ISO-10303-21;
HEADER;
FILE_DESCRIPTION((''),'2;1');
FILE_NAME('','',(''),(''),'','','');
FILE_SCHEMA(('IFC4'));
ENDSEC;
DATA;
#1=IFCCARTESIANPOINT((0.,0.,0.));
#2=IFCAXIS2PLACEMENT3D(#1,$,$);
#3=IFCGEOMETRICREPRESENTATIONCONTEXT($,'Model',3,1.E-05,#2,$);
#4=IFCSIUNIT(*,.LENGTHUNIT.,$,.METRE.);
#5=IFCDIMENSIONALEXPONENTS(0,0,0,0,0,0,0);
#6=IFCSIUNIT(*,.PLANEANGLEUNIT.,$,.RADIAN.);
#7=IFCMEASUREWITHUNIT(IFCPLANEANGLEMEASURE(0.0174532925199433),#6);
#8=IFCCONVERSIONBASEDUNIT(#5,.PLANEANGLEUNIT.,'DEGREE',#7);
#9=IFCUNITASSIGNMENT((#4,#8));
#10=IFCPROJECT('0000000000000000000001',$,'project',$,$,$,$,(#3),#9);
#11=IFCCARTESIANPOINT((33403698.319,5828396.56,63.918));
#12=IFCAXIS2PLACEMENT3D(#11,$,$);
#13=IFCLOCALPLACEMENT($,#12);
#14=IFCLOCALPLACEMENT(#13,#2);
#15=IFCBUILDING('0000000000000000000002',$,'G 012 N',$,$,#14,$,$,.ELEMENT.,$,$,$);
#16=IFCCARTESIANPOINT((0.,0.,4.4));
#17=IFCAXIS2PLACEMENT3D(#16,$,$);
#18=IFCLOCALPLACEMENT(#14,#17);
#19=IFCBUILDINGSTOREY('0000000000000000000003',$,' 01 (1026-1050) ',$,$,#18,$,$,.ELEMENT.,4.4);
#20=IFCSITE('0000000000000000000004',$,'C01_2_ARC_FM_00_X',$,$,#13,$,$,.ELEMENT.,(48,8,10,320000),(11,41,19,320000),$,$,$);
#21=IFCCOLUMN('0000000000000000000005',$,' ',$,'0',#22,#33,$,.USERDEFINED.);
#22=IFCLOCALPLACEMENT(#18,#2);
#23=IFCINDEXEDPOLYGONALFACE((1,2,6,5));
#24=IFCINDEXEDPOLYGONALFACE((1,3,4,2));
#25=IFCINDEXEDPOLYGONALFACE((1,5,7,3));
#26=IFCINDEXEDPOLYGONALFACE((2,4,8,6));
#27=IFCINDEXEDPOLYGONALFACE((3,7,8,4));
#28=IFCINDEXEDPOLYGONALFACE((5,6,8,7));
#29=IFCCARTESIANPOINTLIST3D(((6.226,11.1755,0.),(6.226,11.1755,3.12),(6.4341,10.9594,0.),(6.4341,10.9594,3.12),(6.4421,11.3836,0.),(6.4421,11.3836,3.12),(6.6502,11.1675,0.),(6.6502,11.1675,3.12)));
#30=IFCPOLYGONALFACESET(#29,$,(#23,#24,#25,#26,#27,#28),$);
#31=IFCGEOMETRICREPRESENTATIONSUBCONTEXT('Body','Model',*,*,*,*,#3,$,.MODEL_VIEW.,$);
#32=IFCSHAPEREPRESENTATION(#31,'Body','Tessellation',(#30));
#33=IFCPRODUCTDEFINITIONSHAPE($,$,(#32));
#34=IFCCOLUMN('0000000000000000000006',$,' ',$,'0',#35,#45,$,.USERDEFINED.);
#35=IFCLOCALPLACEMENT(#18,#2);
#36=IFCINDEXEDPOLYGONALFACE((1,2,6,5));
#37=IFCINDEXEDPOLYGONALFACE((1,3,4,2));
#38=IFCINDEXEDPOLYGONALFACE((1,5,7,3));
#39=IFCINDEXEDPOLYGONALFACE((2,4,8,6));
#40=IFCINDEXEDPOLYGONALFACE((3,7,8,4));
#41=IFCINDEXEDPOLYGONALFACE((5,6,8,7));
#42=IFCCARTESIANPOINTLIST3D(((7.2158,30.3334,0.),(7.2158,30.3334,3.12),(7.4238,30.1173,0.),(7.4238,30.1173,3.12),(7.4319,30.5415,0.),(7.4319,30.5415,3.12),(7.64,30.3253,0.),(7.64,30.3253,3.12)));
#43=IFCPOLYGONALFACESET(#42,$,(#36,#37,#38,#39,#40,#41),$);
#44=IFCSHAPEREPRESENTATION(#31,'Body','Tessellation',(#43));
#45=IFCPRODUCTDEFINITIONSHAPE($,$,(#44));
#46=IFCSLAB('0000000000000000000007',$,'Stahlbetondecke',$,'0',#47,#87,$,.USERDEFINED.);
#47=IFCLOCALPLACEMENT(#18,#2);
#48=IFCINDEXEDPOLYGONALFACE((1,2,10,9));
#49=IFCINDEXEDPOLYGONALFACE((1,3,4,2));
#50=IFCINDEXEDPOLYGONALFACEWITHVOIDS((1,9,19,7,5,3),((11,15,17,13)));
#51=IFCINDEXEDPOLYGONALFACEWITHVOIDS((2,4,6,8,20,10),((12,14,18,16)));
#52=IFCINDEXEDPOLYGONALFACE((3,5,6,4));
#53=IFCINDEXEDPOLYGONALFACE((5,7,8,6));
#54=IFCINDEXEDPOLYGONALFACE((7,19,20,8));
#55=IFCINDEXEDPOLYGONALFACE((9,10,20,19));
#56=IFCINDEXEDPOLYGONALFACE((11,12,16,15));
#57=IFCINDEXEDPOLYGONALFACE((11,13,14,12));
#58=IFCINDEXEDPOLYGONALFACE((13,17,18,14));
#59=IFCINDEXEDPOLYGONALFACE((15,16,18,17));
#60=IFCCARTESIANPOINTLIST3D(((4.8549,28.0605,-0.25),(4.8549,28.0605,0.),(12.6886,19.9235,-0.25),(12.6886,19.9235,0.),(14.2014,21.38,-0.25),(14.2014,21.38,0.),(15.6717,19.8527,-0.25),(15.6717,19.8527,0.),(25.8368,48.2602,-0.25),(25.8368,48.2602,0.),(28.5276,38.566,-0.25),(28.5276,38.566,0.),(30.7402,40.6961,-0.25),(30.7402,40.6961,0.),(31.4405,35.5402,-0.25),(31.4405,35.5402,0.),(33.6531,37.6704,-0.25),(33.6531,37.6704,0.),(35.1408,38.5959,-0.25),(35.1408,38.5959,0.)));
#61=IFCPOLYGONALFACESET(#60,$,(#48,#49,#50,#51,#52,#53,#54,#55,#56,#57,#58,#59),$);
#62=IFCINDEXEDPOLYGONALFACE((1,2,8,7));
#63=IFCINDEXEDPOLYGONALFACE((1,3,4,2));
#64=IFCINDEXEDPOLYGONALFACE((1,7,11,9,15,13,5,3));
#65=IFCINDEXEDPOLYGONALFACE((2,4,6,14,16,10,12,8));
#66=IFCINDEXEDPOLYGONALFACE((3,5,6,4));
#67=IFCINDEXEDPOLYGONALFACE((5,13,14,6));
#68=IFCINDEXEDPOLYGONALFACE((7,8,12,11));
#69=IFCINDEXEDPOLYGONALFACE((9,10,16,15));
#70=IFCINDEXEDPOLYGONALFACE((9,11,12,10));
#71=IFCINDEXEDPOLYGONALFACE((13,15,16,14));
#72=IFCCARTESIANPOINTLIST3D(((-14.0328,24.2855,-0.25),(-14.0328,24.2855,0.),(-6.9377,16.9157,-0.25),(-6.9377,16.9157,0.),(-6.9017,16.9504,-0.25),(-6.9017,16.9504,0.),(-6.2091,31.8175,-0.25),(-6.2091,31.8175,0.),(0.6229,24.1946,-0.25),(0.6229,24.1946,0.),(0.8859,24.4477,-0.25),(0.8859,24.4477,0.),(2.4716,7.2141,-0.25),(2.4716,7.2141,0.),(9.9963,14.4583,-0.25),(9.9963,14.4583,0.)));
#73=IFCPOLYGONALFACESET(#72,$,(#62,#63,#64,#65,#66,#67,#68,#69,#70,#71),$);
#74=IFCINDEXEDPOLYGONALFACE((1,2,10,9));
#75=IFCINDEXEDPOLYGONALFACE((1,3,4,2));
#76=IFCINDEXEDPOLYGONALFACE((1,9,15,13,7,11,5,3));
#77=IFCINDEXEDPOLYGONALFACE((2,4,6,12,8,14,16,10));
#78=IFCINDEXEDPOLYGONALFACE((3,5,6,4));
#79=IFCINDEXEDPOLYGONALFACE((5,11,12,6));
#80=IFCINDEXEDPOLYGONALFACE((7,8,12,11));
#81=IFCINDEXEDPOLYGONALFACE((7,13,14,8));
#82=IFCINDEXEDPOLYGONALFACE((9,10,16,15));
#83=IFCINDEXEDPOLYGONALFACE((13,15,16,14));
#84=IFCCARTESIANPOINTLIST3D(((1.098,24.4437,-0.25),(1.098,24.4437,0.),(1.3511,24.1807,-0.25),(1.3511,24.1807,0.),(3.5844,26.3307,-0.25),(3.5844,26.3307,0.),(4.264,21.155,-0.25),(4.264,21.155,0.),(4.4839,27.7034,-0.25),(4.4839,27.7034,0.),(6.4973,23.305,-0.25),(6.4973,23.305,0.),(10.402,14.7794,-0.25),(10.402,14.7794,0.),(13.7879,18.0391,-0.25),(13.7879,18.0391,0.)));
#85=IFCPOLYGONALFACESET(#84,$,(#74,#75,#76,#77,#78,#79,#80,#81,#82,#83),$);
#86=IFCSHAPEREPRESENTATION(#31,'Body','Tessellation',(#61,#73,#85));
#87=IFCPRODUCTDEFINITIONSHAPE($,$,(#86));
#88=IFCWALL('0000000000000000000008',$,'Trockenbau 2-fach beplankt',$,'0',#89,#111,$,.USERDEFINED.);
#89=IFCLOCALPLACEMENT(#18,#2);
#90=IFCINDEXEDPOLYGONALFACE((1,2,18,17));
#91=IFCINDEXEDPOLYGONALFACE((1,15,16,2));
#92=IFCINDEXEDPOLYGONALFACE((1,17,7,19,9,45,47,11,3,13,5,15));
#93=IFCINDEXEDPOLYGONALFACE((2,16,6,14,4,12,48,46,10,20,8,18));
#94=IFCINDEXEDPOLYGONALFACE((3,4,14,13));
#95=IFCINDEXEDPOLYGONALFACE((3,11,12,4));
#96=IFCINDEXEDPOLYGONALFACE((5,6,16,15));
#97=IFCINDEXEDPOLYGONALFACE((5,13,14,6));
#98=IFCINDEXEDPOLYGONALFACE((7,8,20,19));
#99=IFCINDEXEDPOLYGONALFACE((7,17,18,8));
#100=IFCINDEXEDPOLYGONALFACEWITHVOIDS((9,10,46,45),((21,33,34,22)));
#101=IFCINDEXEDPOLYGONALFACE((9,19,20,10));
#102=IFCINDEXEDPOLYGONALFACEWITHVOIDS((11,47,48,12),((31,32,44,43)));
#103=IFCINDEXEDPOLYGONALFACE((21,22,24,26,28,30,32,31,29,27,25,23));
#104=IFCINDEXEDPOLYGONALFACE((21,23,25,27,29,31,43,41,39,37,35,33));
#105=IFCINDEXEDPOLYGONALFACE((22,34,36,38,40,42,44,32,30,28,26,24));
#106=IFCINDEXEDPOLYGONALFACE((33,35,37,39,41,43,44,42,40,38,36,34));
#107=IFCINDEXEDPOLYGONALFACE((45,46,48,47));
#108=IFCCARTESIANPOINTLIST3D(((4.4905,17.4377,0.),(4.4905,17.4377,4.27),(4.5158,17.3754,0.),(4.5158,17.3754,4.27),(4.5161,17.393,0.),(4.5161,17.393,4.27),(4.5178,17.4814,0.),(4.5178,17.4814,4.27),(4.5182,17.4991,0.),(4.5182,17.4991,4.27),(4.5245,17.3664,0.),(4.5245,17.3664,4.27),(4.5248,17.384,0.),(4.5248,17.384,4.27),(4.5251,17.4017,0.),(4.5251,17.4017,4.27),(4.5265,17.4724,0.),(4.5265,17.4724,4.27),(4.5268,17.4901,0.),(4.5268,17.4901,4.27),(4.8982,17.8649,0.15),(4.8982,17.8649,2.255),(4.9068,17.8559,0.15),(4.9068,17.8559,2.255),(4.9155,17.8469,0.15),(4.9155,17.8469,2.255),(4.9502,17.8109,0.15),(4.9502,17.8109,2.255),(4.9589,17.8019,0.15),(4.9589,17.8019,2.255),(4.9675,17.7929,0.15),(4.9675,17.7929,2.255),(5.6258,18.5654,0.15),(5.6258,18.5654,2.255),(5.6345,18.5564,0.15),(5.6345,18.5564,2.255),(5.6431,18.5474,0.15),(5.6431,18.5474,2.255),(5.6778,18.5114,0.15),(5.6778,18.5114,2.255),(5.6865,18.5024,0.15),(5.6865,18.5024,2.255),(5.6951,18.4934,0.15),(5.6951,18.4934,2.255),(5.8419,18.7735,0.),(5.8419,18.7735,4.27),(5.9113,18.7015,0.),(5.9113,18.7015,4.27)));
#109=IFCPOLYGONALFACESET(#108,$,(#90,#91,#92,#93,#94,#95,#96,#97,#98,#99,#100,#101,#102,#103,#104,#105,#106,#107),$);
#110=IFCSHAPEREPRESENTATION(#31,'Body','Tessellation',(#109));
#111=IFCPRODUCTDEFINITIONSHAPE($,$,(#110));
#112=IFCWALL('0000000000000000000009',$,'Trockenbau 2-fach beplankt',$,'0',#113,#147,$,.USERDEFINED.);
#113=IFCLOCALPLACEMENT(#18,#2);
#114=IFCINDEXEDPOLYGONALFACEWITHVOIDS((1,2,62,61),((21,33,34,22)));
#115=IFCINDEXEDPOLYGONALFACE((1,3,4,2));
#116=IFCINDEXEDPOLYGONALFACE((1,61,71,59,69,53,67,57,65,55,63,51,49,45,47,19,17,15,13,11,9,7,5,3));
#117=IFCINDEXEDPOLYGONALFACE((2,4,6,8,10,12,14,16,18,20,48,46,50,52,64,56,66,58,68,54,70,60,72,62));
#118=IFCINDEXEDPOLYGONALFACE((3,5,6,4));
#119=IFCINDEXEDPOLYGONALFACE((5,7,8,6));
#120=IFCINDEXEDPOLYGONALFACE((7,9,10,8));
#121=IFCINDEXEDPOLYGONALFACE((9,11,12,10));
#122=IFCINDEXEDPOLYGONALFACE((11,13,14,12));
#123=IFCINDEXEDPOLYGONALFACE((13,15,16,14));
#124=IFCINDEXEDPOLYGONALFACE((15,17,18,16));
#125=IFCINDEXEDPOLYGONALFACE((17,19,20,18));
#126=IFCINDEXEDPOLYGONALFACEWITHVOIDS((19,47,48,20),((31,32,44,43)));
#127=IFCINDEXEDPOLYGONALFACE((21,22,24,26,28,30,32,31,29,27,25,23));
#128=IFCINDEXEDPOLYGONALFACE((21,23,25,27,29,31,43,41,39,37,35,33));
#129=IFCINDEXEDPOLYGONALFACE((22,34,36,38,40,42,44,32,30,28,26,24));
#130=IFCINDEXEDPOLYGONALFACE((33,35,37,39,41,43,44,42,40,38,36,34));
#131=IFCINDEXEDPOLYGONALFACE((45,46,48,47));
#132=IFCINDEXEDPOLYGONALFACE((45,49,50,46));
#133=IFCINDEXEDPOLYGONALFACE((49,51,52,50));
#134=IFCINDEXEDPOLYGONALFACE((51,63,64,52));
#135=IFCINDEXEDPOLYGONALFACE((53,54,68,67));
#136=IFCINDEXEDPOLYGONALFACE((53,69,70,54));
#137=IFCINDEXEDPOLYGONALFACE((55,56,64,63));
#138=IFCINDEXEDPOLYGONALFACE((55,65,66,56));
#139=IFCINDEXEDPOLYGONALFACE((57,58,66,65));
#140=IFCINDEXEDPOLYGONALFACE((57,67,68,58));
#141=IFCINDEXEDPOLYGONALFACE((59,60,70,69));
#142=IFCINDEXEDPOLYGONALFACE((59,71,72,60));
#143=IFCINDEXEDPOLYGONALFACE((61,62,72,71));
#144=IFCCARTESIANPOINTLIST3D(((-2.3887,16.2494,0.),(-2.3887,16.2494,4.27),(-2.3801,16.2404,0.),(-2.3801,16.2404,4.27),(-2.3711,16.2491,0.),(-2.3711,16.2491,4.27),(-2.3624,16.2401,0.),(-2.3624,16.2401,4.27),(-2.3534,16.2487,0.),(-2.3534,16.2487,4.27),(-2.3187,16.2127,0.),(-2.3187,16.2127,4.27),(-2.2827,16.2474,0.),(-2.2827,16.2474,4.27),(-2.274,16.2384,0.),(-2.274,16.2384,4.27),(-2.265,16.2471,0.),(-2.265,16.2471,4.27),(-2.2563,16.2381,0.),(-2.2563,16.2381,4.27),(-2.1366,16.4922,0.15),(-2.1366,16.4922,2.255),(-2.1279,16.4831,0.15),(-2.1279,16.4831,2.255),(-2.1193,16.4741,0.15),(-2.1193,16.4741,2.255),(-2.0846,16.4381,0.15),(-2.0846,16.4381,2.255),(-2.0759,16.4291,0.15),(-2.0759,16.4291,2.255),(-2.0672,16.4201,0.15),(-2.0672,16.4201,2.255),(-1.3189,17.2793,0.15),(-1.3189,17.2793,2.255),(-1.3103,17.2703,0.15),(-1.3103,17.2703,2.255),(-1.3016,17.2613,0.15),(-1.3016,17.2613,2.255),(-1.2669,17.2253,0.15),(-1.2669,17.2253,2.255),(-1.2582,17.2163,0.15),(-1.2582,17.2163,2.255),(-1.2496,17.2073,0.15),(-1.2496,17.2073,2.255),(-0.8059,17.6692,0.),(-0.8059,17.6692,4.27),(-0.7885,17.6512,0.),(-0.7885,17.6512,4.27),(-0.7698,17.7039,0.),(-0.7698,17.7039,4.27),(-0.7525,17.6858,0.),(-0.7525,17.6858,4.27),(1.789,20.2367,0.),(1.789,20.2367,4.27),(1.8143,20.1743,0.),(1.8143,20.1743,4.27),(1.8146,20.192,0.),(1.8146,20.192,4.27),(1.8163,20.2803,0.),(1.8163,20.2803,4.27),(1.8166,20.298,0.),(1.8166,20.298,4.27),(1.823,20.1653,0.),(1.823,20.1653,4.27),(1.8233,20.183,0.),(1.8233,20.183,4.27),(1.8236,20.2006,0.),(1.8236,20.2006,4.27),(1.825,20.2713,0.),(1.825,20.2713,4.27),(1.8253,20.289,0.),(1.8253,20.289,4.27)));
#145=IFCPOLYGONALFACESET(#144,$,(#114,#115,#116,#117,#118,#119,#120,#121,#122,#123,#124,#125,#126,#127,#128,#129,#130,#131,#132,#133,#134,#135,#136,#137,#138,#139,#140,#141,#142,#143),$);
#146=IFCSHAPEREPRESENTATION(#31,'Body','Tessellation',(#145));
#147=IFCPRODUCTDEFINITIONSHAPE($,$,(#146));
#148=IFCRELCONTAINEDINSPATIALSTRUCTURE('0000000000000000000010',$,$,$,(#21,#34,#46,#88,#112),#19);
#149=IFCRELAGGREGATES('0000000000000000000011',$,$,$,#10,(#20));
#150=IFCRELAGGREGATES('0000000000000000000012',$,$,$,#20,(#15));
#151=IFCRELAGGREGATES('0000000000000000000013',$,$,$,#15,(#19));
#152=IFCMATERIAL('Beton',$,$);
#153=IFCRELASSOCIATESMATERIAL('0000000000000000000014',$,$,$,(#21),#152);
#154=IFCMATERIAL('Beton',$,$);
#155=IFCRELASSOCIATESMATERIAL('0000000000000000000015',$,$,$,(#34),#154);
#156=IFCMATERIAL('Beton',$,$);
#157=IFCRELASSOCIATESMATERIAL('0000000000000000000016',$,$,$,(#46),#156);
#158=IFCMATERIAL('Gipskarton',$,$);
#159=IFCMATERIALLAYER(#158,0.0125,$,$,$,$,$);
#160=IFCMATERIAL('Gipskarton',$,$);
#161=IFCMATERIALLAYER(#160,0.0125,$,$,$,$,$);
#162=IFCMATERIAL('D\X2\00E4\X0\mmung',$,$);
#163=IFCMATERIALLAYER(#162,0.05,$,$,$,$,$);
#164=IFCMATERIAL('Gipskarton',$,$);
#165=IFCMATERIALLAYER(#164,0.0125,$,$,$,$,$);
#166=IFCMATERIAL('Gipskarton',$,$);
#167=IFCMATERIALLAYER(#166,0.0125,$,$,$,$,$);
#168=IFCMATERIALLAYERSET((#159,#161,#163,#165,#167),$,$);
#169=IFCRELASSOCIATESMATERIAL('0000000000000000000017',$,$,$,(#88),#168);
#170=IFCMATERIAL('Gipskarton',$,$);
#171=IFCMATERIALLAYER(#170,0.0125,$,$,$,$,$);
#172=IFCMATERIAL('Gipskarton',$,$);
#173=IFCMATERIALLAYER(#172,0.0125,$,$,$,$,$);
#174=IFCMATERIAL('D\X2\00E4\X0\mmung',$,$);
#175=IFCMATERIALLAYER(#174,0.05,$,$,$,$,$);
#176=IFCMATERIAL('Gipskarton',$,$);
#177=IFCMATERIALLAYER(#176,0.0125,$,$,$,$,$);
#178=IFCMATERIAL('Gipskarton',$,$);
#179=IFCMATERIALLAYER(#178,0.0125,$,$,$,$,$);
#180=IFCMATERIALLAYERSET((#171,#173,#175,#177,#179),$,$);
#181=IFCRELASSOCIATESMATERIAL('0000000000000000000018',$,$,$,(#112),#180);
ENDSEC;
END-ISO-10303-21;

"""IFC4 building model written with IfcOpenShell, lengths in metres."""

from ifc_helpers import new_model, entity, si_unit, converted_unit, frame, frame_2d, origin, origin_with_axes, place, context, subcontext, project, spatial, polyline, rectangle, outline, extrude, material, layer, layer_set, layer_usage, element, save


model = new_model("IFC4")

# Units and contexts
model_context = context("Model", 3, precision=1e-05, world=origin())
body_context = subcontext(model_context, "Body", "Model", "MODEL_VIEW")
ifc_project = project(units=[si_unit("LENGTHUNIT", "METRE"), converted_unit("PLANEANGLEUNIT", "DEGREE", entity("IfcPlaneAngleMeasure", 0.0174532925199433), si_unit("PLANEANGLEUNIT", "RADIAN"), dimensions=[0, 0, 0, 0, 0, 0, 0])], contexts=[model_context])

# Site, building, storey
site_placement = place(None, frame((33403698.319, 5828396.56, 63.918)))
site = spatial("IfcSite", under=ifc_project, at=site_placement, Name="C01_2_ARC_FM_00_X", CompositionType="ELEMENT", RefLatitude=(48, 8, 10, 320000), RefLongitude=(11, 41, 19, 320000))
building_placement = place(site_placement, origin())
building = spatial("IfcBuilding", under=site, at=building_placement, Name="G 012 N", CompositionType="ELEMENT")
storey_placement = place(building_placement, frame((0.0, 0.0, 4.4)))
storey = spatial("IfcBuildingStorey", under=building, at=storey_placement, Name=" 01 (1026-1050) ", CompositionType="ELEMENT", Elevation=4.4)

# Columns
ifc_material_1 = material(Name="Beton")
column_1_placement = place(storey_placement, frame((6.4341, 10.9594, 0.0)))
element("IfcColumn", 1, at=column_1_placement, inside=storey, material=ifc_material_1, Name=" ", ObjectType="0", PredefinedType="USERDEFINED", context=body_context, shape_type="SweptSolid", body=[
    extrude(rectangle(XDim=0.3, YDim=0.3, at=frame_2d((0.004, 0.2121), x_axis=(0.720408, 0.693551))), origin_with_axes(), (0.0, 0.0, 1.0), 3.12),
])
ifc_material_2 = material(Name="Beton")
column_2_placement = place(storey_placement, frame((7.4238, 30.1173, 0.0)))
element("IfcColumn", 2, at=column_2_placement, inside=storey, material=ifc_material_2, Name=" ", ObjectType="0", PredefinedType="USERDEFINED", context=body_context, shape_type="SweptSolid", body=[
    extrude(rectangle(XDim=0.3, YDim=0.3, at=frame_2d((0.004, 0.2121), x_axis=(0.720408, 0.693551))), origin_with_axes(), (0.0, 0.0, 1.0), 3.12),
])

# Slab
ifc_material_3 = material(Name="Beton")
slab_placement = place(storey_placement, frame((-14.0328, 7.2141, -0.25)))
element("IfcSlab", 3, at=slab_placement, inside=storey, material=ifc_material_3, Name="Stahlbetondecke", ObjectType="0", PredefinedType="USERDEFINED", context=body_context, shape_type="SweptSolid", body=[
    extrude(outline(polyline([(30.2859, 18.7432), (20.9819, 28.4075), (0.0, 8.2078), (7.8337, 0.0708), (9.3465, 1.5273), (10.8168, 0.0), (30.2859, 18.7432)]), holes=[polyline([(25.8853, 20.8434), (28.7982, 17.8177), (26.5856, 15.6875), (23.6726, 18.7132), (25.8853, 20.8434)])]), frame((18.8877, 12.6386, 0.0), z_axis=(0.0, 0.0, 1.0), x_axis=(1.0, 0.0, 0.0)), (0.0, 0.0, 1.0), 0.25),
    extrude(outline(polyline([(14.9187, 17.2336), (7.8236, 24.6034), (0.0, 17.0714), (7.095, 9.7016), (7.131, 9.7363), (16.5044, 0.0), (24.029, 7.2441), (14.6557, 16.9804), (14.9187, 17.2336)])), origin_with_axes(), (0.0, 0.0, 1.0), 0.25),
    extrude(outline(polyline([(2.4864, 11.5513), (5.3993, 8.5256), (3.1661, 6.3756), (9.304, 0.0), (12.6899, 3.2597), (3.3859, 12.924), (0.0, 9.6643), (0.2531, 9.4013), (2.4864, 11.5513)])), frame((15.1307, 7.5653, 0.0), z_axis=(0.0, 0.0, 1.0), x_axis=(1.0, 0.0, 0.0)), (0.0, 0.0, 1.0), 0.25),
])

# Wall, opening
ifc_material_4 = material(Name="Gipskarton")
ifc_layer_1 = layer(ifc_material_4, 0.0125)
ifc_material_5 = material(Name="Gipskarton")
ifc_layer_2 = layer(ifc_material_5, 0.0125)
ifc_material_6 = material(Name="Dämmung")
ifc_layer_3 = layer(ifc_material_6, 0.05)
ifc_material_7 = material(Name="Gipskarton")
ifc_layer_4 = layer(ifc_material_7, 0.0125)
ifc_material_8 = material(Name="Gipskarton")
ifc_layer_5 = layer(ifc_material_8, 0.0125)
ifc_layer_set_1 = layer_set([ifc_layer_1, ifc_layer_2, ifc_layer_3, ifc_layer_4, ifc_layer_5])
ifc_layer_usage_1 = layer_usage(ifc_layer_set_1, "AXIS2", "POSITIVE", 0.0)
wall_1_placement = place(storey_placement, frame((5.8419, 18.7735, 0.0), z_axis=(0.0, 0.0, 1.0), x_axis=(-0.720408, -0.693551, 0.0)))
wall_1 = element("IfcWall", 4, at=wall_1_placement, inside=storey, material=ifc_layer_usage_1, Name="Trockenbau 2-fach beplankt", ObjectType="0", PredefinedType="USERDEFINED", context=body_context, shape_type="SweptSolid", body=[
    extrude(outline(polyline([(-1.9495, -0.0764), (-0.112, -0.0764), (-0.112, -0.0639), (-0.0995, -0.0639), (-0.0995, -0.0514), (-0.0495, -0.0514), (-0.0495, -0.0014), (-0.037, -0.0014), (-0.037, 0.0111), (-0.0245, 0.0111), (-0.0245, 0.0236), (-1.9495, 0.0236), (-1.9495, -0.0764)])), frame((1.9495, 0.0764, 0.0), z_axis=(0.0, 0.0, 1.0), x_axis=(1.0, 0.0, 0.0)), (0.0, 0.0, 1.0), 4.27),
])
opening_1_placement = place(wall_1_placement, frame((0.3, 0.0, 0.15), z_axis=(0.0, 1.0, 0.0), x_axis=(0.0, 0.0, 1.0)))
element("IfcOpeningElement", 5, at=opening_1_placement, cuts=wall_1, ObjectType="0", PredefinedType="USERDEFINED", context=body_context, shape_type="SweptSolid", body=[
    extrude(outline(polyline([(0.0, 1.01), (2.105, 1.01), (2.105, 0.0), (0.0, 0.0), (0.0, 1.01)])), origin_with_axes(), (0.0, 0.0, 1.0), 0.0125),
    extrude(outline(polyline([(0.0, 1.01), (2.105, 1.01), (2.105, 0.0), (0.0, 0.0), (0.0, 1.01)])), frame((0.0, 0.0, 0.0125), z_axis=(0.0, 0.0, 1.0), x_axis=(1.0, 0.0, 0.0)), (0.0, 0.0, 1.0), 0.0125),
    extrude(outline(polyline([(0.0, 1.01), (2.105, 1.01), (2.105, 0.0), (0.0, 0.0), (0.0, 1.01)])), frame((0.0, 0.0, 0.025), z_axis=(0.0, 0.0, 1.0), x_axis=(1.0, 0.0, 0.0)), (0.0, 0.0, 1.0), 0.05),
    extrude(outline(polyline([(0.0, 1.01), (2.105, 1.01), (2.105, 0.0), (0.0, 0.0), (0.0, 1.01)])), frame((0.0, 0.0, 0.075), z_axis=(0.0, 0.0, 1.0), x_axis=(1.0, 0.0, 0.0)), (0.0, 0.0, 1.0), 0.0125),
    extrude(outline(polyline([(0.0, 1.01), (2.105, 1.01), (2.105, 0.0), (0.0, 0.0), (0.0, 1.01)])), frame((0.0, 0.0, 0.0875), z_axis=(0.0, 0.0, 1.0), x_axis=(1.0, 0.0, 0.0)), (0.0, 0.0, 1.0), 0.0125),
])

# Wall, opening
ifc_material_9 = material(Name="Gipskarton")
ifc_layer_6 = layer(ifc_material_9, 0.0125)
ifc_material_10 = material(Name="Gipskarton")
ifc_layer_7 = layer(ifc_material_10, 0.0125)
ifc_material_11 = material(Name="Dämmung")
ifc_layer_8 = layer(ifc_material_11, 0.05)
ifc_material_12 = material(Name="Gipskarton")
ifc_layer_9 = layer(ifc_material_12, 0.0125)
ifc_material_13 = material(Name="Gipskarton")
ifc_layer_10 = layer(ifc_material_13, 0.0125)
ifc_layer_set_2 = layer_set([ifc_layer_6, ifc_layer_7, ifc_layer_8, ifc_layer_9, ifc_layer_10])
ifc_layer_usage_2 = layer_usage(ifc_layer_set_2, "AXIS2", "POSITIVE", 0.0)
wall_2_placement = place(storey_placement, frame((1.8166, 20.298, 0.0), z_axis=(0.0, 0.0, 1.0), x_axis=(-0.720408, -0.693551, 0.0)))
wall_2 = element("IfcWall", 6, at=wall_2_placement, inside=storey, material=ifc_layer_usage_2, Name="Trockenbau 2-fach beplankt", ObjectType="0", PredefinedType="USERDEFINED", context=body_context, shape_type="SweptSolid", body=[
    extrude(outline(polyline([(-2.1504, 0.0486), (-2.2004, 0.0486), (-2.2004, 0.0736), (-5.7754, 0.0736), (-5.7754, 0.0611), (-5.7879, 0.0611), (-5.7879, 0.0486), (-5.8004, 0.0486), (-5.8004, -0.0014), (-5.8504, -0.0014), (-5.8504, -0.0139), (-5.8629, -0.0139), (-5.8629, -0.0264), (-0.0254, -0.0264), (-0.0254, -0.0139), (-0.0379, -0.0139), (-0.0379, -0.0014), (-0.0504, -0.0014), (-0.0504, 0.0486), (-0.1004, 0.0486), (-0.1004, 0.0611), (-0.1129, 0.0611), (-0.1129, 0.0736), (-2.1504, 0.0736), (-2.1504, 0.0486)])), frame((5.8629, 0.0264, 0.0), z_axis=(0.0, 0.0, 1.0), x_axis=(1.0, 0.0, 0.0)), (0.0, 0.0, 1.0), 4.27),
])
opening_2_placement = place(wall_2_placement, frame((5.4875, 0.0125, 0.15), z_axis=(0.0, -1.0, 0.0), x_axis=(0.0, 0.0, 1.0)))
element("IfcOpeningElement", 7, at=opening_2_placement, cuts=wall_2, ObjectType="0", PredefinedType="USERDEFINED", context=body_context, shape_type="SweptSolid", body=[
    extrude(outline(polyline([(0.0, 1.135), (2.105, 1.135), (2.105, 0.0), (0.0, 0.0), (0.0, 1.135)])), origin_with_axes(), (0.0, 0.0, 1.0), 0.0125),
    extrude(outline(polyline([(0.0, 1.135), (2.105, 1.135), (2.105, 0.0), (0.0, 0.0), (0.0, 1.135)])), frame((0.0, 0.0, -0.0125), z_axis=(0.0, 0.0, 1.0), x_axis=(1.0, 0.0, 0.0)), (0.0, 0.0, 1.0), 0.0125),
    extrude(outline(polyline([(0.0, 1.135), (2.105, 1.135), (2.105, 0.0), (0.0, 0.0), (0.0, 1.135)])), frame((0.0, 0.0, -0.0625), z_axis=(0.0, 0.0, 1.0), x_axis=(1.0, 0.0, 0.0)), (0.0, 0.0, 1.0), 0.05),
    extrude(outline(polyline([(0.0, 1.135), (2.105, 1.135), (2.105, 0.0), (0.0, 0.0), (0.0, 1.135)])), frame((0.0, 0.0, -0.075), z_axis=(0.0, 0.0, 1.0), x_axis=(1.0, 0.0, 0.0)), (0.0, 0.0, 1.0), 0.0125),
    extrude(outline(polyline([(0.0, 1.135), (2.105, 1.135), (2.105, 0.0), (0.0, 0.0), (0.0, 1.135)])), frame((0.0, 0.0, -0.0875), z_axis=(0.0, 0.0, 1.0), x_axis=(1.0, 0.0, 0.0)), (0.0, 0.0, 1.0), 0.0125),
])

save(model, "model.ifc")
